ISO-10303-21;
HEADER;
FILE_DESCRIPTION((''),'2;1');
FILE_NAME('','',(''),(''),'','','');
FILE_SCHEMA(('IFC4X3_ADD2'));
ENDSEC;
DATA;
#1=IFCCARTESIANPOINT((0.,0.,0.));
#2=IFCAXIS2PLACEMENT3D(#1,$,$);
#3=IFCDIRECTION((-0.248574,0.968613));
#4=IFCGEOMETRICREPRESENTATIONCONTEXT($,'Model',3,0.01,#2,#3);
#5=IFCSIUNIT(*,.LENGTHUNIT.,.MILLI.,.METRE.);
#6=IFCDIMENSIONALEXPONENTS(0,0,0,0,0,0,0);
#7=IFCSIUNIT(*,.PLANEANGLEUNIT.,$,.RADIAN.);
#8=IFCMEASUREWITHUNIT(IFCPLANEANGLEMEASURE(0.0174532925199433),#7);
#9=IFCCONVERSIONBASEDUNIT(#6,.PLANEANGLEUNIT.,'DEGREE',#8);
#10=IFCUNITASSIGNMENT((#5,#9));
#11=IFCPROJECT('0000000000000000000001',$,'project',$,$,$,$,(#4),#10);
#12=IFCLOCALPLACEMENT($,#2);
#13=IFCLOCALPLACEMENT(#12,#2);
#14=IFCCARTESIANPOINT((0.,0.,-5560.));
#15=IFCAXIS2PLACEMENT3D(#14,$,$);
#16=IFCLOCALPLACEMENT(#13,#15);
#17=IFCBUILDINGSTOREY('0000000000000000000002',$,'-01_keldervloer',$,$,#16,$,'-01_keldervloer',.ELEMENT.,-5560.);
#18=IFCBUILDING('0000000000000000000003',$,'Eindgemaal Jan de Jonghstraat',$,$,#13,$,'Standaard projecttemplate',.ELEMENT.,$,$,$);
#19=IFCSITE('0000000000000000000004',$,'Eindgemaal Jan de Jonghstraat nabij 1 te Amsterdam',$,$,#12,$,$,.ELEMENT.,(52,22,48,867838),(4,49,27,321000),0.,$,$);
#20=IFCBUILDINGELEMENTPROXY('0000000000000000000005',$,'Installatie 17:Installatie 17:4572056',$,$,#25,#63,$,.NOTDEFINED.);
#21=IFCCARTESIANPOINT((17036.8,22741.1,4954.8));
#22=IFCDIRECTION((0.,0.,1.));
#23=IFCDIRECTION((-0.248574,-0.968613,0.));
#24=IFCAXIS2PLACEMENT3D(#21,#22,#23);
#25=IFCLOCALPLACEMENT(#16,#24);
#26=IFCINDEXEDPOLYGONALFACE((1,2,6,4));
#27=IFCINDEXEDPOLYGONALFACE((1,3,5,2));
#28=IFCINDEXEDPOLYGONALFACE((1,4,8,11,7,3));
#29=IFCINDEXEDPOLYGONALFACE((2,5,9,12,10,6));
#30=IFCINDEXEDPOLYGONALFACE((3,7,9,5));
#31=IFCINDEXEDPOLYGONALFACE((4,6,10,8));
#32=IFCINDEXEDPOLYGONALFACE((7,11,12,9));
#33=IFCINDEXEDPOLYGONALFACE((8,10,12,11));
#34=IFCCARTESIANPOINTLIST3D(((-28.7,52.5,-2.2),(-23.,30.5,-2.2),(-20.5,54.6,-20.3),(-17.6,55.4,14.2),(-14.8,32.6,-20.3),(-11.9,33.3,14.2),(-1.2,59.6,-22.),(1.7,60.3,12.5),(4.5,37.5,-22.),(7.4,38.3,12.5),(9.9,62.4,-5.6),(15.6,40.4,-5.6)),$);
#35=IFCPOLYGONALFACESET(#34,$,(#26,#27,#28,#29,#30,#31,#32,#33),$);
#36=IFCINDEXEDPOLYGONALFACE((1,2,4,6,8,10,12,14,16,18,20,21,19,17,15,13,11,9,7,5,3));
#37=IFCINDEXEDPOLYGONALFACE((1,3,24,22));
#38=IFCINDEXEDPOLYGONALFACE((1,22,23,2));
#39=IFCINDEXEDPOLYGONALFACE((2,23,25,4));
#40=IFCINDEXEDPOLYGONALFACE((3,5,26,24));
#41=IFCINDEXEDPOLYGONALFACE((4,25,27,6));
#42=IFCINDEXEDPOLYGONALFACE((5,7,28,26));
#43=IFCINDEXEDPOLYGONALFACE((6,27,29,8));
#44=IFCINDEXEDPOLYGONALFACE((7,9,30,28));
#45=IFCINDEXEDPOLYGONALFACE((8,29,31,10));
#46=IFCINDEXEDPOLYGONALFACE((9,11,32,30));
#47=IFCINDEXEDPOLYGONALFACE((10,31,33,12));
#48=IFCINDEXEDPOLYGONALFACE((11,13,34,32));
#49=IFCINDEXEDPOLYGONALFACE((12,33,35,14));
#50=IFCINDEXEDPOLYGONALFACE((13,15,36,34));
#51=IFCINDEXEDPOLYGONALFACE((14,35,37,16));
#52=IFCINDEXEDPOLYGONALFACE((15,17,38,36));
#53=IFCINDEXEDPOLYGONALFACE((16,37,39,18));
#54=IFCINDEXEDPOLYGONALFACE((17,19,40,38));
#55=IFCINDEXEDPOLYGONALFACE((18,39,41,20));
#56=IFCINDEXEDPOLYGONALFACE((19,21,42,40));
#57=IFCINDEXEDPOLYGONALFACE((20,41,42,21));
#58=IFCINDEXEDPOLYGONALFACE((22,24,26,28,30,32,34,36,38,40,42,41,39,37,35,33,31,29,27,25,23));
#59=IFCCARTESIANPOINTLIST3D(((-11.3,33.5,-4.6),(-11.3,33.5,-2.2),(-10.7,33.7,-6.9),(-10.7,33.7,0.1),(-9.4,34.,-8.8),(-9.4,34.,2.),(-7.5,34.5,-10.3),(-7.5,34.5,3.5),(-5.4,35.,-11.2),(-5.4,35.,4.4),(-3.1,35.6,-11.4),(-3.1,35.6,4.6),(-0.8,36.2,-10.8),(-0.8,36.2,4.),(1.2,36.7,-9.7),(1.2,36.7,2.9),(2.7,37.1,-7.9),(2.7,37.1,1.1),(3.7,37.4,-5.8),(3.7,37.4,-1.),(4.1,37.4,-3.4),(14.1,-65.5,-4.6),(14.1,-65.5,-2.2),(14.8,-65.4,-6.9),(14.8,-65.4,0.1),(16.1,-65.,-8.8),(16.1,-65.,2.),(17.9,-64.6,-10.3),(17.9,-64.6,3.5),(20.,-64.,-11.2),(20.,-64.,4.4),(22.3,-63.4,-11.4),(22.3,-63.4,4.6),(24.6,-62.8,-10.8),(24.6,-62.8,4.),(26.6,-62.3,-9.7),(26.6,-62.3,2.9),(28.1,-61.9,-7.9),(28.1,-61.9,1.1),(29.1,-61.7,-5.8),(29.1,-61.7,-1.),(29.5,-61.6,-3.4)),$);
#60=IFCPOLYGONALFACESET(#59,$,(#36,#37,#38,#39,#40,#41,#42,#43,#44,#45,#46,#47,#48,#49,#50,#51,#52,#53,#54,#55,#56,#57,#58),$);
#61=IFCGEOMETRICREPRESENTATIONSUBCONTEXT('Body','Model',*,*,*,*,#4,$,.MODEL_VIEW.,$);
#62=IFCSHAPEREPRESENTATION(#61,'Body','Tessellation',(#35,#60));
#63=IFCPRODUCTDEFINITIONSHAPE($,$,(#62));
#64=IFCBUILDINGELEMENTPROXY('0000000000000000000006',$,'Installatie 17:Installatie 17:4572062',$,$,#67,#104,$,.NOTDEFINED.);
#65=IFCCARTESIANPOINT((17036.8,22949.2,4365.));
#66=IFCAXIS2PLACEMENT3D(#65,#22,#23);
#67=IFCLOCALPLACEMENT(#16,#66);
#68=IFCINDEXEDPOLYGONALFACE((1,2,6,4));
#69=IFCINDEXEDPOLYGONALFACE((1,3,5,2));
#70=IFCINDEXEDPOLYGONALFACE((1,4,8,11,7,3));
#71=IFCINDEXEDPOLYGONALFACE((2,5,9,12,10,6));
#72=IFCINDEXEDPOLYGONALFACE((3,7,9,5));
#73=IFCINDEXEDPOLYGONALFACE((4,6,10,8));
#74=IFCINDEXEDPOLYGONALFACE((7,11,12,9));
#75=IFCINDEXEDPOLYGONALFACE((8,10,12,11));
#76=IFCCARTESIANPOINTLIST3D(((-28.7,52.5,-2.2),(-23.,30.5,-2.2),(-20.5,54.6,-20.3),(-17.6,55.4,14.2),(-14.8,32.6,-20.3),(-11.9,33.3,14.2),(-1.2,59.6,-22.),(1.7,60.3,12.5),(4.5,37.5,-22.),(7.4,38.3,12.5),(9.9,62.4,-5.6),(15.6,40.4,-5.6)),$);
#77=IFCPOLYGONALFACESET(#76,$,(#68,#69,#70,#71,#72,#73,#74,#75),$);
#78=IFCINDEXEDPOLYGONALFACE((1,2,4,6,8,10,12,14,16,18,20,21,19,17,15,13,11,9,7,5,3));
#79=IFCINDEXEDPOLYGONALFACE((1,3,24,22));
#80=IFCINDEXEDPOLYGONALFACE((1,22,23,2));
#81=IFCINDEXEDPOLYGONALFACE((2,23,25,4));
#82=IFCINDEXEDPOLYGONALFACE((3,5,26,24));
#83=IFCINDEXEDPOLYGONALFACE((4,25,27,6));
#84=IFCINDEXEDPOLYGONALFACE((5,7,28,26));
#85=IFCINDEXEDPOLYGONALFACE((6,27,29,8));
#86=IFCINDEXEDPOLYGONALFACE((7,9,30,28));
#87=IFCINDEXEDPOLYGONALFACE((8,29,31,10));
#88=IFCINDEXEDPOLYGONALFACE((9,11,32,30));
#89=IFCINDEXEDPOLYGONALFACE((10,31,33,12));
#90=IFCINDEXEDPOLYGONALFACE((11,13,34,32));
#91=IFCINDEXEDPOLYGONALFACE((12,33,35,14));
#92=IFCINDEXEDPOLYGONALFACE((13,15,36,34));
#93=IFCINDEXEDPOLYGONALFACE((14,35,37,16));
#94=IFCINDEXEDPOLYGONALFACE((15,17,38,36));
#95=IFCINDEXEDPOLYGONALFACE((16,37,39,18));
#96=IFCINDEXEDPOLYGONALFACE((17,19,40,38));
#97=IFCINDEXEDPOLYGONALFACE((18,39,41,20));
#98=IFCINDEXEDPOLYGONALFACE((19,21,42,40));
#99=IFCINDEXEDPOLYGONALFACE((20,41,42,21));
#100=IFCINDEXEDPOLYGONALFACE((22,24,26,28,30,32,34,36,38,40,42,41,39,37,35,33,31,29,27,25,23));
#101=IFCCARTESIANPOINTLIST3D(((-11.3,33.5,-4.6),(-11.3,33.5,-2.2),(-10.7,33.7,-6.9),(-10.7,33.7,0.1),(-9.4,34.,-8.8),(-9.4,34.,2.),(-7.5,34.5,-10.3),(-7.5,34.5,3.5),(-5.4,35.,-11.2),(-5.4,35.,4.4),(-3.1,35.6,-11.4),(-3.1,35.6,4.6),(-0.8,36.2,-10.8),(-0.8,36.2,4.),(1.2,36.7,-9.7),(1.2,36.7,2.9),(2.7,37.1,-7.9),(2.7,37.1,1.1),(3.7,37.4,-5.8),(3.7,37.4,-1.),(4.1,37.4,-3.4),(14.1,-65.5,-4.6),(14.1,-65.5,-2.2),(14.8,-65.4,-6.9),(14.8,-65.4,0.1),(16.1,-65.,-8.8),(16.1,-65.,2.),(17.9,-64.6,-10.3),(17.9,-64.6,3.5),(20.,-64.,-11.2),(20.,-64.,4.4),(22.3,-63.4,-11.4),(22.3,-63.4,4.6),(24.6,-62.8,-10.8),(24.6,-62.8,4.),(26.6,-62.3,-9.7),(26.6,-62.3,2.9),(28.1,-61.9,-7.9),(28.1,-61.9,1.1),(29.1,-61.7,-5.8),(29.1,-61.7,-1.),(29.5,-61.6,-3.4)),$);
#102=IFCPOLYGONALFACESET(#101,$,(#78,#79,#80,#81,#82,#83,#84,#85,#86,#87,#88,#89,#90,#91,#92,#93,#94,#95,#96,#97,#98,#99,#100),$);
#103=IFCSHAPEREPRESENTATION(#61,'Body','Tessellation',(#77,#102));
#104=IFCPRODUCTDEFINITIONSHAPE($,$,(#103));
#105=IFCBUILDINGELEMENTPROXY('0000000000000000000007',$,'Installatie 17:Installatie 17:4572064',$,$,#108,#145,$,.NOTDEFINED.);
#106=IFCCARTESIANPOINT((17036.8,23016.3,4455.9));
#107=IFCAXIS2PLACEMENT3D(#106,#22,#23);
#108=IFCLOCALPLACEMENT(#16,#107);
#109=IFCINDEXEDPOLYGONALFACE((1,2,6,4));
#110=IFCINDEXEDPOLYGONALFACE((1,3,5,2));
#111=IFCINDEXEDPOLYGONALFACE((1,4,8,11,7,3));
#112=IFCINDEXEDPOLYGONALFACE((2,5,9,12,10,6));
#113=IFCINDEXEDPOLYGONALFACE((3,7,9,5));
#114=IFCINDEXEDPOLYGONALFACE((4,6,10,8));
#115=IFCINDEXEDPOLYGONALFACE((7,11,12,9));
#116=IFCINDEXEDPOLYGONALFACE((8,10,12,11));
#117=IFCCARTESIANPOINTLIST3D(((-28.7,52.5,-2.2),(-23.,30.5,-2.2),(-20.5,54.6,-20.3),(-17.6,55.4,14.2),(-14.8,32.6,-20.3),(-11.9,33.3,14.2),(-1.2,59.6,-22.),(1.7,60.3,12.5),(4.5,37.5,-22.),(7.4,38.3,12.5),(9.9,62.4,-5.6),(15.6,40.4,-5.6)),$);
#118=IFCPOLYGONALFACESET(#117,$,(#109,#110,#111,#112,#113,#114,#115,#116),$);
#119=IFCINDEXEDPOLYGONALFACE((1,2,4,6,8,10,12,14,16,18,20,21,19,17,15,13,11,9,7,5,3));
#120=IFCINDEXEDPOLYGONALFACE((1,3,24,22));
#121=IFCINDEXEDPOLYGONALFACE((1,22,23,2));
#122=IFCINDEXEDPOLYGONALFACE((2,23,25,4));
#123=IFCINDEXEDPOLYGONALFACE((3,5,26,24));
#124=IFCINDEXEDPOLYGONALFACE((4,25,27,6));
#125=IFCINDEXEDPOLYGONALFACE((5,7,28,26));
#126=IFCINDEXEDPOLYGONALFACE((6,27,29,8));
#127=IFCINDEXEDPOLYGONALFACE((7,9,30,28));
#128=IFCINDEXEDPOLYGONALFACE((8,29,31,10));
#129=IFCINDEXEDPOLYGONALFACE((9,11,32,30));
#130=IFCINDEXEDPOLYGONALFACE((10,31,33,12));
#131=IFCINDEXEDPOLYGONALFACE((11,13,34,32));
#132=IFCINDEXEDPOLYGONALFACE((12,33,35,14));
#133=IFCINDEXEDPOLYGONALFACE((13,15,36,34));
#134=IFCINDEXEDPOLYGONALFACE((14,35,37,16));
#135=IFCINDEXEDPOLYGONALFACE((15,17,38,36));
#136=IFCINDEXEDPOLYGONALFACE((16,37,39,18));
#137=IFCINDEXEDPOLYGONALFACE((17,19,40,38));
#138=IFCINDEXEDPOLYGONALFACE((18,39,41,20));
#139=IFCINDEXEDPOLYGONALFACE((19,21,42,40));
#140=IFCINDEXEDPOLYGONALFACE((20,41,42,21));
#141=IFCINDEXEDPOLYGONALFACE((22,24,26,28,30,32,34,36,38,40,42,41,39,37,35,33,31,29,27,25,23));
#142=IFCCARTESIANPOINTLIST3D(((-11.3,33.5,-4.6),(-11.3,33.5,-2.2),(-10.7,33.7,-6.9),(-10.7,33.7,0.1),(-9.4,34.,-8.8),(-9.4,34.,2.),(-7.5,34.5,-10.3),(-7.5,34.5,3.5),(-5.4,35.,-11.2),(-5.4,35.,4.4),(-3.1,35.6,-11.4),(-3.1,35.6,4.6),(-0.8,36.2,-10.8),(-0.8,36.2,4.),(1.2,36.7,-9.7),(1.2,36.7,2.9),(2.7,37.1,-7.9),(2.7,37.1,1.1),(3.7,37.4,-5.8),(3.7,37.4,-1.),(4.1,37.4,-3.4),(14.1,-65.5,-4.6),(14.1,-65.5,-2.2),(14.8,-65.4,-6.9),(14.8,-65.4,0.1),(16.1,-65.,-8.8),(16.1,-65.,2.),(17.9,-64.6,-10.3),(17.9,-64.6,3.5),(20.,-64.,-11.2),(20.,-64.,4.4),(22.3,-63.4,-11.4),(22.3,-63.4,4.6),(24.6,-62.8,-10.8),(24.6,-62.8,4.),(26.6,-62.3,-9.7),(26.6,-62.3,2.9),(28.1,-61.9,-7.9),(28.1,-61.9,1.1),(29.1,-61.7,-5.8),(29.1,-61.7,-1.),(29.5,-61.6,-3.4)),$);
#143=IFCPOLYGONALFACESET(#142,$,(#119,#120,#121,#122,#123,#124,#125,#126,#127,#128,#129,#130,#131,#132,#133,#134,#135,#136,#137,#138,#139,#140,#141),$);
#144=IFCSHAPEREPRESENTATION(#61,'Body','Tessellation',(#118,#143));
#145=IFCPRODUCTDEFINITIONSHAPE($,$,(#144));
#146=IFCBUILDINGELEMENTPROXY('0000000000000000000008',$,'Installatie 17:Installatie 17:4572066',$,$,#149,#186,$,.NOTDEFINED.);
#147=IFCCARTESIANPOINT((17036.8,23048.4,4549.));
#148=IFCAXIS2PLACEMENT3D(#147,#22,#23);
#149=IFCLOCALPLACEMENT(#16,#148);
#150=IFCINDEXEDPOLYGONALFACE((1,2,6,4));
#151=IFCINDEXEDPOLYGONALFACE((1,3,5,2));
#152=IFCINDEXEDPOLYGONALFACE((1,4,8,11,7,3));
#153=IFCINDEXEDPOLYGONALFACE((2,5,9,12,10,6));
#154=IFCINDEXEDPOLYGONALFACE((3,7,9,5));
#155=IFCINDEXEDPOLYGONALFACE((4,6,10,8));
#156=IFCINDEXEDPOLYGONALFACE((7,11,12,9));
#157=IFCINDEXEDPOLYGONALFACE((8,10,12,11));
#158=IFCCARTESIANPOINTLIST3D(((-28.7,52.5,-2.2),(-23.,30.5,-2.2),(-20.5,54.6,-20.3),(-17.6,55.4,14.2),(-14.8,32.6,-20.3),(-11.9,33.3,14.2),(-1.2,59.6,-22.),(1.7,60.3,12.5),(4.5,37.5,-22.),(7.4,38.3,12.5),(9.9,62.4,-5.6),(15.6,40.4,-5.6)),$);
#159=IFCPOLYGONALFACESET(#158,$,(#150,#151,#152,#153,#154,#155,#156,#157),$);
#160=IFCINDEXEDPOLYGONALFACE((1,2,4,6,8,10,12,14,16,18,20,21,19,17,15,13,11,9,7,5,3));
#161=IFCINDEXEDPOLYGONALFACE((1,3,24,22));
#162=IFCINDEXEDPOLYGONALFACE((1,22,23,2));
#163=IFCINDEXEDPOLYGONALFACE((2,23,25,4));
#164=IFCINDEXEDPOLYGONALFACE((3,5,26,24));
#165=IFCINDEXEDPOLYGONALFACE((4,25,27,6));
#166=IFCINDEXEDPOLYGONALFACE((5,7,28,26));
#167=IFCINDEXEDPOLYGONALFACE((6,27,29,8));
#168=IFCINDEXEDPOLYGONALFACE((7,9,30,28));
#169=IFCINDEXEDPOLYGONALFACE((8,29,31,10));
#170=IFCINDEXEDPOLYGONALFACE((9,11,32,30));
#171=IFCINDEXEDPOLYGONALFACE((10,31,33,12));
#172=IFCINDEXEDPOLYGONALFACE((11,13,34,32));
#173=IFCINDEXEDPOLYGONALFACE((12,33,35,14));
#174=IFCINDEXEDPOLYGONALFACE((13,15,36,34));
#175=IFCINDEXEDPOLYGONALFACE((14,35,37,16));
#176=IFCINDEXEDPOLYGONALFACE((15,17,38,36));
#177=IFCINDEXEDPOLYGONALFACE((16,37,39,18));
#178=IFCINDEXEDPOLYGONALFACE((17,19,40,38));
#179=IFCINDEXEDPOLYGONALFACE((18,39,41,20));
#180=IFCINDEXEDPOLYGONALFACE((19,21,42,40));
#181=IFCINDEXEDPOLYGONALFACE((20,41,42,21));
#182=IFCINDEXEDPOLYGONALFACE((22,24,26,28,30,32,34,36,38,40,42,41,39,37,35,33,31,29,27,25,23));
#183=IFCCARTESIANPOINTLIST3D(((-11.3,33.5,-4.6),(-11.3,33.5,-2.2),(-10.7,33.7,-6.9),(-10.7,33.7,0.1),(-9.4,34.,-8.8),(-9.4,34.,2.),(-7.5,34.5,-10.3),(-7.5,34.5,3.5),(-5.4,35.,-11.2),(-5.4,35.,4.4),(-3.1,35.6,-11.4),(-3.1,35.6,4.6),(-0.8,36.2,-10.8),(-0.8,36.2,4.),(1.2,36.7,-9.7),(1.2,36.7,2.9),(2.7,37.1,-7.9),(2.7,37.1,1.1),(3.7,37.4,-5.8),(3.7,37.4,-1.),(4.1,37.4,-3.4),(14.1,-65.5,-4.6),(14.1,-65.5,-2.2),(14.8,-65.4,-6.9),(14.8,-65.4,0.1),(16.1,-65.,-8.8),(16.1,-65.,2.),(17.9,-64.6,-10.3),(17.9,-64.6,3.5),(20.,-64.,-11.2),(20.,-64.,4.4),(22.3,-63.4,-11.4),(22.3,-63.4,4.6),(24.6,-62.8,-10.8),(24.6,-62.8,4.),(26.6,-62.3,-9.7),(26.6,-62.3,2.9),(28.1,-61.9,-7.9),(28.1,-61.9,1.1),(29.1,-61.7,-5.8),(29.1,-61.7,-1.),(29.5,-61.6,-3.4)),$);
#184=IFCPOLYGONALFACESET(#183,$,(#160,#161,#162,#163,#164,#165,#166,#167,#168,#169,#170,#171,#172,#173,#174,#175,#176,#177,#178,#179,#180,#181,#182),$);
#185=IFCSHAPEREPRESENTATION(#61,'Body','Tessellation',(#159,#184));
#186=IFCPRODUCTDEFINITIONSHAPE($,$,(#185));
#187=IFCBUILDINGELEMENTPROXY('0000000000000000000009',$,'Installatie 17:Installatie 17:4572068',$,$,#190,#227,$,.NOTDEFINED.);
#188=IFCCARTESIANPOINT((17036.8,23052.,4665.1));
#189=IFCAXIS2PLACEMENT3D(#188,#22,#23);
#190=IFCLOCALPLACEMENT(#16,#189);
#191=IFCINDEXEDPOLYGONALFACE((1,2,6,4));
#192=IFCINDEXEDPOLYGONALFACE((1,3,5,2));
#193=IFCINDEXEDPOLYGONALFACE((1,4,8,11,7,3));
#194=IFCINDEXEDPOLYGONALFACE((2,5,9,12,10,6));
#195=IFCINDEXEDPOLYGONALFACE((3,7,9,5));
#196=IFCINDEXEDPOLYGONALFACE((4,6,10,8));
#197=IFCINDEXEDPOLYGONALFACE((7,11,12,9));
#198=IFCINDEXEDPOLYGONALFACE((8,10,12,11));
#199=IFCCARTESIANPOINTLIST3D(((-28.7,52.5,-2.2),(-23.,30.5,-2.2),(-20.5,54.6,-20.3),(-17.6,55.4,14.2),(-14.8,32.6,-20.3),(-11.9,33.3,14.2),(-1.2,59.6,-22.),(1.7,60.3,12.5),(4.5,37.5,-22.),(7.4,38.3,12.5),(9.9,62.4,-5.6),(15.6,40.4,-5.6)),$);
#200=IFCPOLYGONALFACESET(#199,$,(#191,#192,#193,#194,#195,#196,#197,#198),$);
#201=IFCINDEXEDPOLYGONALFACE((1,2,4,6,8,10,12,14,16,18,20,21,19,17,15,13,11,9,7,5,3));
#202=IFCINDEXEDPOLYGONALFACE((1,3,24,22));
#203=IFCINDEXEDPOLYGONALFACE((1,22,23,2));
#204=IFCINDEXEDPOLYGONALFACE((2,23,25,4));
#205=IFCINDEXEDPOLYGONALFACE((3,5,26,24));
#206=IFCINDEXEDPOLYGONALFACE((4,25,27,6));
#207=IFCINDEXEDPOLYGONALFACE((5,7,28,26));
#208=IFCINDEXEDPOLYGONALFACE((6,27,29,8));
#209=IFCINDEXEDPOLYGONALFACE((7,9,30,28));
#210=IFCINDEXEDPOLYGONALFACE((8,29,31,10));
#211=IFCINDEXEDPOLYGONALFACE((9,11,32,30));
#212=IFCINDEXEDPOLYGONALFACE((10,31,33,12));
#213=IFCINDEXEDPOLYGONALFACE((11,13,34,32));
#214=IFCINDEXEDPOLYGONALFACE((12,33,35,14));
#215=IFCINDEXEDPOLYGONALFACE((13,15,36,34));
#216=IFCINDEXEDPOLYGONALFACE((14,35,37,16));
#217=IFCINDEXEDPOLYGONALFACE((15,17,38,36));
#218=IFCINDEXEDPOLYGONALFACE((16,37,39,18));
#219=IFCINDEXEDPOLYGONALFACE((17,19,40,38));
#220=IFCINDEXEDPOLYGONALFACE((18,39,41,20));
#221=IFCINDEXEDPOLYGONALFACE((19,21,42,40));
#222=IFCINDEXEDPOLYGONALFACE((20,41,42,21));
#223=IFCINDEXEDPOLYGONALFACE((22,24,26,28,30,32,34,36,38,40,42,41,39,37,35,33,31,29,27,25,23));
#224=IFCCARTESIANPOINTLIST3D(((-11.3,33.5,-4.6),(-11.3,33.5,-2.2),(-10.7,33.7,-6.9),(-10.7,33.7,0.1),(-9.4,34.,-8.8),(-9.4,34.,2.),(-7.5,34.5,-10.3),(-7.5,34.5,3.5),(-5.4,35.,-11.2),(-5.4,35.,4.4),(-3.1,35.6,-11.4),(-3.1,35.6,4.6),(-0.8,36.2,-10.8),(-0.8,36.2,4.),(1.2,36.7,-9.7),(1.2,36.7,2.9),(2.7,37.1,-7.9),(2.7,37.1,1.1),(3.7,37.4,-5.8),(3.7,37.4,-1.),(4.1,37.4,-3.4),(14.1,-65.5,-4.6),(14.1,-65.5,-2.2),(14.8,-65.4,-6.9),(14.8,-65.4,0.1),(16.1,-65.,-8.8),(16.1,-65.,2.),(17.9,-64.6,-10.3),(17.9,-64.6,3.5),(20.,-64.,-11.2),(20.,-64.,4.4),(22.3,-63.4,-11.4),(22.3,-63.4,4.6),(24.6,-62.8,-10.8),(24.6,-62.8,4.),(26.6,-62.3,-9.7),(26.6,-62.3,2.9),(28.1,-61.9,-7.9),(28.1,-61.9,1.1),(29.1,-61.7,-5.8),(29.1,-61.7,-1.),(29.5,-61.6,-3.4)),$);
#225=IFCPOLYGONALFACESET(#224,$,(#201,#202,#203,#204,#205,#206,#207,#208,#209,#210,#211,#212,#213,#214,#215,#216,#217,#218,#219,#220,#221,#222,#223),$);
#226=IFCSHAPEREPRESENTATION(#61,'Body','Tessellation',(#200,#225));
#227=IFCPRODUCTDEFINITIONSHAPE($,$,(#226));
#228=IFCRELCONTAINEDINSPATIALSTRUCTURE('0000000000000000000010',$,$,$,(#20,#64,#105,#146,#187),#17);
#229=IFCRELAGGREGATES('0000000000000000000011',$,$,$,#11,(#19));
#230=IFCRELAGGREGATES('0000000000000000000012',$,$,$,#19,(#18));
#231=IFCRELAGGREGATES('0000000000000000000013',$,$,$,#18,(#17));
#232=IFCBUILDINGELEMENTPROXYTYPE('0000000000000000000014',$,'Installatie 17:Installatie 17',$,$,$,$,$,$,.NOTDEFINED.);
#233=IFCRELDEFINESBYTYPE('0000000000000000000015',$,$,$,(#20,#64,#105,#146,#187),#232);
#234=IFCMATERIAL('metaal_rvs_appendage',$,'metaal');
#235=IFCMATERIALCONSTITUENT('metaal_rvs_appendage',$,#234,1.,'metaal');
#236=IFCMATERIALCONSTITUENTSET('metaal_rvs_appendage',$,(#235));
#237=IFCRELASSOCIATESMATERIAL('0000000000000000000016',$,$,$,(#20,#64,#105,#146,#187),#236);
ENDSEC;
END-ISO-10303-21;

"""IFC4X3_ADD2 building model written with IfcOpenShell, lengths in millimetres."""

from ifc_helpers import new_model, entity, si_unit, converted_unit, direction, frame, frame_2d, origin, place, context, subcontext, project, spatial, polyline, circle, outline, extrude, source, transform, mapped, material, constituent, constituent_set, type_object, type_shapes, element, save


model = new_model("IFC4X3_ADD2")

# Units and contexts
model_context = context("Model", 3, precision=0.01, world=origin(), true_north=direction((-0.248574, 0.968613)))
body_context = subcontext(model_context, "Body", "Model", "MODEL_VIEW")
ifc_project = project(units=[si_unit("LENGTHUNIT", "METRE", prefix="MILLI"), converted_unit("PLANEANGLEUNIT", "DEGREE", entity("IfcPlaneAngleMeasure", 0.0174532925199433), si_unit("PLANEANGLEUNIT", "RADIAN"), dimensions=[0, 0, 0, 0, 0, 0, 0])], contexts=[model_context])

# Site, building, storey
site_placement = place(None, origin())
site = spatial("IfcSite", under=ifc_project, at=site_placement, Name="Eindgemaal Jan de Jonghstraat nabij 1 te Amsterdam", CompositionType="ELEMENT", RefLatitude=(52, 22, 48, 867838), RefLongitude=(4, 49, 27, 321000), RefElevation=0.0)
building_placement = place(site_placement, origin())
building = spatial("IfcBuilding", under=site, at=building_placement, Name="Eindgemaal Jan de Jonghstraat", LongName="Standaard projecttemplate", CompositionType="ELEMENT")
storey_placement = place(building_placement, frame((0.0, 0.0, -5560.0)))
storey = spatial("IfcBuildingStorey", under=building, at=storey_placement, Name="-01_keldervloer", LongName="-01_keldervloer", CompositionType="ELEMENT", Elevation=-5560.0)

# Building element proxies
ifc_material_1 = material(Name="metaal_rvs_appendage", Category="metaal")
ifc_constituent_1 = constituent(ifc_material_1, Name="metaal_rvs_appendage", Category="metaal", fraction=1.0)
ifc_constituent_set_1 = constituent_set(constituents=[ifc_constituent_1], Name="metaal_rvs_appendage")
building_element_proxy_type_1 = type_object("IfcBuildingElementProxyType", Name="Installatie 17:Installatie 17", PredefinedType="NOTDEFINED")
shared_shape_1 = source(origin(), body_context, "Body", "SweptSolid", [
    extrude(outline(polyline([(-10.0, -17.3), (10.0, -17.3), (20.0, 0.0), (10.0, 17.3), (-10.0, 17.3), (-20.0, 0.0), (-10.0, -17.3)])), frame((-3.7, 35.4, -3.9), z_axis=(-0.248574, 0.968613, 0.0), x_axis=(-0.555573, -0.142576, -0.819152)), (0.0, 0.0, 1.0), 22.8),
    extrude(circle(Radius=8.0, at=frame_2d((0.0, 0.0), x_axis=(1.0, 0.0))), frame((21.7, -63.6, -3.4), z_axis=(-0.248574, 0.968613, 0.0), x_axis=(0.968613, 0.248574, 0.0)), (0.0, 0.0, 1.0), 102.2),
])
type_shapes(building_element_proxy_type_1, [shared_shape_1])
for number, where, z_axis, x_axis, name in (
    (1, (17036.8, 22741.1, 4954.8), (0.0, 0.0, 1.0), (-0.248574, -0.968613, 0.0), "Installatie 17:Installatie 17:4572056"),
    (2, (17036.8, 22949.2, 4365.0), (0.0, 0.0, 1.0), (-0.248574, -0.968613, 0.0), "Installatie 17:Installatie 17:4572062"),
    (3, (17036.8, 23016.3, 4455.9), (0.0, 0.0, 1.0), (-0.248574, -0.968613, 0.0), "Installatie 17:Installatie 17:4572064"),
    (4, (17036.8, 23048.4, 4549.0), (0.0, 0.0, 1.0), (-0.248574, -0.968613, 0.0), "Installatie 17:Installatie 17:4572066"),
    (5, (17036.8, 23052.0, 4665.1), (0.0, 0.0, 1.0), (-0.248574, -0.968613, 0.0), "Installatie 17:Installatie 17:4572068"),
):
    element("IfcBuildingElementProxy", number, at=place(storey_placement, frame(where, z_axis=z_axis, x_axis=x_axis)), inside=storey, type_object=building_element_proxy_type_1, material=ifc_constituent_set_1, Name=name, PredefinedType="NOTDEFINED", context=body_context, shape_type="MappedRepresentation", body=[
        mapped(shared_shape_1, transform((0.0, 0.0, 0.0), scale=1.0)),
    ])

save(model, "model.ifc")
